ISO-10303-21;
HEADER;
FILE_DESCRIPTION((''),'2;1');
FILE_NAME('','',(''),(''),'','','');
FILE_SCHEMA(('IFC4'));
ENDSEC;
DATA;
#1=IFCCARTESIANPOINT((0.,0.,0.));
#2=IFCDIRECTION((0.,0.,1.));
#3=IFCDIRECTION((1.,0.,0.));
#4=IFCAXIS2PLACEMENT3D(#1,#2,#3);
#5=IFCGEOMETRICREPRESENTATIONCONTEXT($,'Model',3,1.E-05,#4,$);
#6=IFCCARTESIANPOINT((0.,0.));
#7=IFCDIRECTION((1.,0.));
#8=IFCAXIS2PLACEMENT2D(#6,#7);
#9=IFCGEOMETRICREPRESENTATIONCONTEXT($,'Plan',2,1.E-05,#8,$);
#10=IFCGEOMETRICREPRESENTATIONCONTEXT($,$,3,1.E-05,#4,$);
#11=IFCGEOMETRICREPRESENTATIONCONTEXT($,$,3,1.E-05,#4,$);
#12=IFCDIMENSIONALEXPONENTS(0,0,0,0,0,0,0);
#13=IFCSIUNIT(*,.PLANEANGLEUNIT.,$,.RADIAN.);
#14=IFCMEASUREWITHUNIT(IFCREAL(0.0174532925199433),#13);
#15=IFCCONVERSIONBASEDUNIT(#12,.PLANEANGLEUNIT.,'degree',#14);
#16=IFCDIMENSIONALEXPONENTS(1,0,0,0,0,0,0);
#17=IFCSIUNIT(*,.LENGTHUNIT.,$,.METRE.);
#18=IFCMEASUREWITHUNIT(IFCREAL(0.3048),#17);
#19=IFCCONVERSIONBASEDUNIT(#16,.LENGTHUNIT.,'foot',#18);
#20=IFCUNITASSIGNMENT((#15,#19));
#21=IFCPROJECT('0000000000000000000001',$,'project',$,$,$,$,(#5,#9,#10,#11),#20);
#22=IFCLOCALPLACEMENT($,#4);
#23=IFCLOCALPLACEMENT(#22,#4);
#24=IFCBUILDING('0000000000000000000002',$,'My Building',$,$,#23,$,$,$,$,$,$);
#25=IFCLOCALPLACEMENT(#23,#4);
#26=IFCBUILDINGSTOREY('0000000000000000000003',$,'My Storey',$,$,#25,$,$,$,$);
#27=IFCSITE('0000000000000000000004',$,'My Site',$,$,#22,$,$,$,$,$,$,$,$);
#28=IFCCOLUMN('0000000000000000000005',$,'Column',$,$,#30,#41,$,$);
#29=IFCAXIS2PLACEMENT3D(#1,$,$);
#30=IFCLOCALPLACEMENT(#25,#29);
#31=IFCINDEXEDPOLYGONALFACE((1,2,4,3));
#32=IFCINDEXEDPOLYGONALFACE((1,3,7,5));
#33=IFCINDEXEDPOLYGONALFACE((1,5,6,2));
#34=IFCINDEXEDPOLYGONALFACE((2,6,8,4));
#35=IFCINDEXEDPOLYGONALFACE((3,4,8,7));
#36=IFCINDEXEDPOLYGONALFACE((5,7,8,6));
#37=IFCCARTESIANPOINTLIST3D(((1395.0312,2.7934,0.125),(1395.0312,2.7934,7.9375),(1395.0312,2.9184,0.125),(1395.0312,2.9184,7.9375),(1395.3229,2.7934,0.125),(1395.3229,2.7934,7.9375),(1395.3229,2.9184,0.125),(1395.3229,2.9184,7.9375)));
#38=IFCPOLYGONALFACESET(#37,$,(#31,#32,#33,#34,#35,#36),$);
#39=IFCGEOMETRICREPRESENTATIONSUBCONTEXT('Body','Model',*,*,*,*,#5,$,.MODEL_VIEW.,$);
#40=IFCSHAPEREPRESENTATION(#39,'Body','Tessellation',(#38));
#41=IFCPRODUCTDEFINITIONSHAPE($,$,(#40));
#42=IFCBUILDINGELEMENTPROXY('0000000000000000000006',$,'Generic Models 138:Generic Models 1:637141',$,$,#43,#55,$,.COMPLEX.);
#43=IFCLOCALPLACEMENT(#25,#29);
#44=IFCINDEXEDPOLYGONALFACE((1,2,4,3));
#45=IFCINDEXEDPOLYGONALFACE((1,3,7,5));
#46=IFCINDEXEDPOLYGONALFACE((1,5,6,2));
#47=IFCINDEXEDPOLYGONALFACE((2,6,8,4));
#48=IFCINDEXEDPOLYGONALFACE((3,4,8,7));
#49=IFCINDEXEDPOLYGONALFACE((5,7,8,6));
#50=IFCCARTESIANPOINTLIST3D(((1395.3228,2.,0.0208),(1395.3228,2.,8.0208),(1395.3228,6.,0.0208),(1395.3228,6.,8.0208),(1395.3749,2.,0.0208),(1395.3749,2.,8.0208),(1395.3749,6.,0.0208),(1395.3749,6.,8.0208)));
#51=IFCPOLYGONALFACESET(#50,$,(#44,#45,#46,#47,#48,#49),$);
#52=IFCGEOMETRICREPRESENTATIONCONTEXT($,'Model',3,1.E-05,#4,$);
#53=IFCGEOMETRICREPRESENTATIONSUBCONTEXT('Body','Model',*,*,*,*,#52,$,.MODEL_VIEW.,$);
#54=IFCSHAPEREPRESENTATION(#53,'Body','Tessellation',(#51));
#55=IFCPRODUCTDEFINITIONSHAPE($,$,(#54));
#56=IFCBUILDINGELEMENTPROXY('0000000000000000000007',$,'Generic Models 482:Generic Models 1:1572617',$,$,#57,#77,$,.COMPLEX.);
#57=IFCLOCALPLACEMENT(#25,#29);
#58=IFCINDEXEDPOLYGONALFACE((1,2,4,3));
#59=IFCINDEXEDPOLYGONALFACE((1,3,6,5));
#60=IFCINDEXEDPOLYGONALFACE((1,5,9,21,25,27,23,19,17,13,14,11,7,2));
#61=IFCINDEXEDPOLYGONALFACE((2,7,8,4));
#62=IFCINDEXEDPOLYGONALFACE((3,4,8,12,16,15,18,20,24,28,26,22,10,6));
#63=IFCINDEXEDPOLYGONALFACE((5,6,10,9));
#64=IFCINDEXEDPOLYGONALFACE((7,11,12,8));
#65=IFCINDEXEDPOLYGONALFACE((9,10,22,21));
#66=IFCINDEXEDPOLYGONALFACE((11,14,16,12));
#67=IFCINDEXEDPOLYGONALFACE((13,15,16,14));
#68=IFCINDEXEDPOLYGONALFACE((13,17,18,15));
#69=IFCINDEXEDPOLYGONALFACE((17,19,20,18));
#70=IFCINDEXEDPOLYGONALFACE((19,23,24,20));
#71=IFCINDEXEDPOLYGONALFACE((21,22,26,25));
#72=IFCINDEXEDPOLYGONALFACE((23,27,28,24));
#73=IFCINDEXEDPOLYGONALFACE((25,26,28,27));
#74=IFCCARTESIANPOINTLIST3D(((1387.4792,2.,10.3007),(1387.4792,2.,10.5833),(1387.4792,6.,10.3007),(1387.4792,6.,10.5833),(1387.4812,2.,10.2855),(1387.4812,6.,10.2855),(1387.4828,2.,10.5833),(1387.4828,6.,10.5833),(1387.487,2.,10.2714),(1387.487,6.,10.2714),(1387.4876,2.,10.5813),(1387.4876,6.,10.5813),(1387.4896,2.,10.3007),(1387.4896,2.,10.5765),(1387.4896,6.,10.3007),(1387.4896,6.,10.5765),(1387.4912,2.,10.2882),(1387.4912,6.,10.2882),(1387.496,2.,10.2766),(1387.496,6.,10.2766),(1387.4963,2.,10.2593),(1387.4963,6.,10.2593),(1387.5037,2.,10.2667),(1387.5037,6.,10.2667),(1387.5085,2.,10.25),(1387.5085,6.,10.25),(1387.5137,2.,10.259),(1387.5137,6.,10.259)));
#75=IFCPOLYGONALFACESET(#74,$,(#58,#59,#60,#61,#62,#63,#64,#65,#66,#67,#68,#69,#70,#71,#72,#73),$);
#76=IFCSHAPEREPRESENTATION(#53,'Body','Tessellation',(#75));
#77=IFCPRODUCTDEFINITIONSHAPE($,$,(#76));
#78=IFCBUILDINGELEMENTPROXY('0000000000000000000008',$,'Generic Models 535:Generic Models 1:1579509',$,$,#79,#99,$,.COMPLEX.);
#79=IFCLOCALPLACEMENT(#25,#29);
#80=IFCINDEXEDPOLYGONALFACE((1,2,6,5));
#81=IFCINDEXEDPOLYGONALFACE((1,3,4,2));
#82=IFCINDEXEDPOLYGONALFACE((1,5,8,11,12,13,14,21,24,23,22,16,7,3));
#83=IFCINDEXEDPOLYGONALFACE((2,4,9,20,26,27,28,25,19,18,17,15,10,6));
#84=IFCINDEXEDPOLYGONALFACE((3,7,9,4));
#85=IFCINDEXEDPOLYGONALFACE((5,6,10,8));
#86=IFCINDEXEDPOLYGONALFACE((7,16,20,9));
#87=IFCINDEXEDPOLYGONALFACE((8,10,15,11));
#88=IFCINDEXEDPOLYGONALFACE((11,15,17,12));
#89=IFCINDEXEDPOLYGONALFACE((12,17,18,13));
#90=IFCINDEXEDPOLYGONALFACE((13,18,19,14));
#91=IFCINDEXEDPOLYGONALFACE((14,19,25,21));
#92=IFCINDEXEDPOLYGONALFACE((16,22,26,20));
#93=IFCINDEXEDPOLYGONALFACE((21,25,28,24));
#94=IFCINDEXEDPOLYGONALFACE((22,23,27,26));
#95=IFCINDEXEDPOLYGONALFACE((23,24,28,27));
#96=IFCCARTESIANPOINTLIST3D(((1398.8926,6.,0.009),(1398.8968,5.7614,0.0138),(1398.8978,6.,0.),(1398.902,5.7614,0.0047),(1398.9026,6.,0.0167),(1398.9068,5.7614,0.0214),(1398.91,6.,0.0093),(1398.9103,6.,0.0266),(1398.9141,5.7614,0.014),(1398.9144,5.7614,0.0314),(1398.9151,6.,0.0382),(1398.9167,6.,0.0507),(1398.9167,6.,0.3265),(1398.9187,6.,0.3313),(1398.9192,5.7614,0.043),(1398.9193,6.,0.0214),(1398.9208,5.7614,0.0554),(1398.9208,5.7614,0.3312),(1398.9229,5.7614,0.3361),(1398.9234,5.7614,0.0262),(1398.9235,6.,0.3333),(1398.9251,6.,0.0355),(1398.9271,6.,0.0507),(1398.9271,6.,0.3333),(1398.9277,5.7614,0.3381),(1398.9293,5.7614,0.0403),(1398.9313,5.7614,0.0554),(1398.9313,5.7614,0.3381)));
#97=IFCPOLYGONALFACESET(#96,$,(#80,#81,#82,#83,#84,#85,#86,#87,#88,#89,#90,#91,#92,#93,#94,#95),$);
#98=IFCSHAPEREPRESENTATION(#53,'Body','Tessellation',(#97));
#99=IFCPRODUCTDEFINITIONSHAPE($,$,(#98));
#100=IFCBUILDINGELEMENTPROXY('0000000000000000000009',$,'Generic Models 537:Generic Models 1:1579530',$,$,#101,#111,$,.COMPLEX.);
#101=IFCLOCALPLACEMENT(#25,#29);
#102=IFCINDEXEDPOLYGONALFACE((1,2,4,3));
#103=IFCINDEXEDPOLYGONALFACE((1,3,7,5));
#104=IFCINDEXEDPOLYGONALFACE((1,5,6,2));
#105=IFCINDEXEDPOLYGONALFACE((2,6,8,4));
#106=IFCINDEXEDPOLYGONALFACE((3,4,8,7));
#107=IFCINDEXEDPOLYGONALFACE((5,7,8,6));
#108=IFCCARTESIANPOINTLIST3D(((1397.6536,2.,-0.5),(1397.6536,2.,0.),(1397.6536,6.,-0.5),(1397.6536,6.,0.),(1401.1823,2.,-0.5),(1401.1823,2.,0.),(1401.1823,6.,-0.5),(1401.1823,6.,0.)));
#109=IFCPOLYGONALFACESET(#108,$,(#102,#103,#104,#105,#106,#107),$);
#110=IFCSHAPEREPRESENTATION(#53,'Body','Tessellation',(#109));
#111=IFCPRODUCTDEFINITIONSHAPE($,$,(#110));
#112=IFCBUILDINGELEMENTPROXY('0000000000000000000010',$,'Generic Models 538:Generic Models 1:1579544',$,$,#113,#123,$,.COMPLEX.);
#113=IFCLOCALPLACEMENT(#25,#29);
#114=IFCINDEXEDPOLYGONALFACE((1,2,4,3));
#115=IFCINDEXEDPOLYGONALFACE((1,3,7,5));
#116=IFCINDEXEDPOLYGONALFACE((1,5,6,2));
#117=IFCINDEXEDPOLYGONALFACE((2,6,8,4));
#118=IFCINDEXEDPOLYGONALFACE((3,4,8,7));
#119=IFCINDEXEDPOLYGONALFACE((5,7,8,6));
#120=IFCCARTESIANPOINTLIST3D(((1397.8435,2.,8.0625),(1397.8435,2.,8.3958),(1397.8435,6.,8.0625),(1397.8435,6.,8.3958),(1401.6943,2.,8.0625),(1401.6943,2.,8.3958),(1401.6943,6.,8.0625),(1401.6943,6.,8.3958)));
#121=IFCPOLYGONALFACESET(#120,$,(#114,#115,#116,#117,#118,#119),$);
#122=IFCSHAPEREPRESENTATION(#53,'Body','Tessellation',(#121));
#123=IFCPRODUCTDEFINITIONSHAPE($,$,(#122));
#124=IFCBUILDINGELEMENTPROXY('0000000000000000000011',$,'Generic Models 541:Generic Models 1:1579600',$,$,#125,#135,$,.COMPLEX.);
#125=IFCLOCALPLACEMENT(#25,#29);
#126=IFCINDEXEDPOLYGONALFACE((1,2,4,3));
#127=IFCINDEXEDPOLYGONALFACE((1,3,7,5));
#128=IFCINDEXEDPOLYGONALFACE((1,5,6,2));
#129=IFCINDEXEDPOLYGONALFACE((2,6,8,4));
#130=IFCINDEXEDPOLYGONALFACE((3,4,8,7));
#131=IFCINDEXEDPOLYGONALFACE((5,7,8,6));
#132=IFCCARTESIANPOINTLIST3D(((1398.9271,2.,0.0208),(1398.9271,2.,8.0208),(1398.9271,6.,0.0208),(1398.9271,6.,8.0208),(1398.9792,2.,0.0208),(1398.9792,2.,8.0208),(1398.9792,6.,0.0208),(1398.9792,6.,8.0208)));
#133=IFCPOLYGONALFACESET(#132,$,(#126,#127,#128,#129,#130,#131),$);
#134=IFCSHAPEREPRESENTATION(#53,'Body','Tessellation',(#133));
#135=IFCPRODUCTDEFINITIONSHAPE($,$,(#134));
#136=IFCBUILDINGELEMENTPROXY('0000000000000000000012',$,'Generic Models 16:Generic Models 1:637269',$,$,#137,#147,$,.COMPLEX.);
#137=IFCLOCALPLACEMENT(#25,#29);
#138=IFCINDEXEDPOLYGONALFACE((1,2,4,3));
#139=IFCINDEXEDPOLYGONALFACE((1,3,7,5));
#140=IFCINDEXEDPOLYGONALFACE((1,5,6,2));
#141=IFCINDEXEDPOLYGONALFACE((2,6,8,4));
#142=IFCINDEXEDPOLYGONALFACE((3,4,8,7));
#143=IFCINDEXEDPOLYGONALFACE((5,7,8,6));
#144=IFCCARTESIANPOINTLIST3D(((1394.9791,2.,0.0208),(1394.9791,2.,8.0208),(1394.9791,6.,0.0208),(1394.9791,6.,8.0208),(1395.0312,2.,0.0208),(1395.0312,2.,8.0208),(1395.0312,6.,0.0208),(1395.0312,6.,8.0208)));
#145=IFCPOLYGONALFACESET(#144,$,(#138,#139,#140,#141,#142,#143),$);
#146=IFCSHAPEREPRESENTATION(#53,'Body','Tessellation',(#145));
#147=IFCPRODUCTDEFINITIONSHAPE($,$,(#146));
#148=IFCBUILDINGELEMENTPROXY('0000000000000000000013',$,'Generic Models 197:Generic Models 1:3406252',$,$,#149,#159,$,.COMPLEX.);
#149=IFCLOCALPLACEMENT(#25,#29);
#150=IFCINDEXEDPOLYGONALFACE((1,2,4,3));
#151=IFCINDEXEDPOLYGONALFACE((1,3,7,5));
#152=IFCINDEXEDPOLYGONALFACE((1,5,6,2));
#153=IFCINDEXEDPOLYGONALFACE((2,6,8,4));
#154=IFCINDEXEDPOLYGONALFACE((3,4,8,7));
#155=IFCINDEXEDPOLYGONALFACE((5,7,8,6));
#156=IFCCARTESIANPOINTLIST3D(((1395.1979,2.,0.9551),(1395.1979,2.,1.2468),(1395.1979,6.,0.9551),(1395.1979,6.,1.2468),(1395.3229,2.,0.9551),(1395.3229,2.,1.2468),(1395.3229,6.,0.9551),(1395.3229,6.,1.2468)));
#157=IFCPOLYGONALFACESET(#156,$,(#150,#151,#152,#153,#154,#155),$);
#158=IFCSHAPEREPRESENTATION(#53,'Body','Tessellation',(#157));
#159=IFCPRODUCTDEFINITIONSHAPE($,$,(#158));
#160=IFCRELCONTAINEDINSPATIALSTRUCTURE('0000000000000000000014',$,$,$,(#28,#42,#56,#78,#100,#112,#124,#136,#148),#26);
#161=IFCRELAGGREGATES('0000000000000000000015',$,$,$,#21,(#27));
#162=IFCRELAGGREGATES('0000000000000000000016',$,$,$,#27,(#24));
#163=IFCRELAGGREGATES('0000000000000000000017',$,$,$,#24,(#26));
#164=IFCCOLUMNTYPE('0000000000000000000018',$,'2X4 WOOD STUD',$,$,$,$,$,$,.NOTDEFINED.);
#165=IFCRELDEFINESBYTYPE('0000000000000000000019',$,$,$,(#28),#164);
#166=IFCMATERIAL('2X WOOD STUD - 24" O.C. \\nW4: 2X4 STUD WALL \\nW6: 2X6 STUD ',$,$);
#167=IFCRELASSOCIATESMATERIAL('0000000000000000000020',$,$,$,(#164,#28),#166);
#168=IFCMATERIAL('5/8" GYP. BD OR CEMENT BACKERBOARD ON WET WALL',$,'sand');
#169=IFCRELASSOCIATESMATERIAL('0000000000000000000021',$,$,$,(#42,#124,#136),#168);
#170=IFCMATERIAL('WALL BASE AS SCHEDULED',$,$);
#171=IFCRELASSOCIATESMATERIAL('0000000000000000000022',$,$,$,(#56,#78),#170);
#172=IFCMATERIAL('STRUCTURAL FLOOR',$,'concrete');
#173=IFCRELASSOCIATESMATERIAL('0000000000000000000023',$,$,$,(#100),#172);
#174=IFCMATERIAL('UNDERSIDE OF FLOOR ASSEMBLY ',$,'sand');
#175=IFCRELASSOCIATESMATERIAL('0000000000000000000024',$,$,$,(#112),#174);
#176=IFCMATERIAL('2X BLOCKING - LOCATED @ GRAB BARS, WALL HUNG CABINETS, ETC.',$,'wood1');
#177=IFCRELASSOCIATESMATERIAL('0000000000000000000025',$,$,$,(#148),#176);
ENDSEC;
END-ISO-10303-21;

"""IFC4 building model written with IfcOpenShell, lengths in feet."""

from ifc_helpers import new_model, entity, si_unit, converted_unit, frame, origin_with_axes, origin_2d_with_axis, place, context, subcontext, project, spatial, polyline, line, indexed_curve, outline, extrude, material, material_profile, profile_set, profile_usage, type_object, element, save


model = new_model("IFC4")

# Units and contexts
model_context_1 = context("Model", 3, precision=1e-05, world=origin_with_axes())
plan_context = context("Plan", 2, precision=1e-05, world=origin_2d_with_axis())
model_context_2 = context("Model", 3, precision=1e-05, world=origin_with_axes())
context_of_model_1 = context(None, 3, precision=1e-05, world=origin_with_axes())
context_of_model_2 = context(None, 3, precision=1e-05, world=origin_with_axes())
body_context_1 = subcontext(model_context_1, "Body", "Model", "MODEL_VIEW")
body_context_2 = subcontext(model_context_2, "Body", "Model", "MODEL_VIEW")
ifc_project = project(units=[converted_unit("PLANEANGLEUNIT", "degree", entity("IfcReal", 0.0174532925199433), si_unit("PLANEANGLEUNIT", "RADIAN"), dimensions=[0, 0, 0, 0, 0, 0, 0]), converted_unit("LENGTHUNIT", "foot", entity("IfcReal", 0.3048), si_unit("LENGTHUNIT", "METRE"), dimensions=[1, 0, 0, 0, 0, 0, 0])], contexts=[model_context_1, plan_context, context_of_model_1, context_of_model_2])

# Site, building, storey
site_placement = place(None, origin_with_axes())
site = spatial("IfcSite", under=ifc_project, at=site_placement, Name="My Site")
building_placement = place(site_placement, origin_with_axes())
building = spatial("IfcBuilding", under=site, at=building_placement, Name="My Building")
storey_placement = place(building_placement, origin_with_axes())
storey = spatial("IfcBuildingStorey", under=building, at=storey_placement, Name="My Storey")

# Column
ifc_material_1 = material(Name="2X WOOD STUD - 24\" O.C. \\nW4: 2X4 STUD WALL \\nW6: 2X6 STUD ")
ifc_material_profile = material_profile(ifc_material_1, outline(indexed_curve([(0.2917, 0.125), (0.0, 0.125), (0.0, 0.0), (0.2917, 0.0)], segments=[line(3, 2), line(2, 1), line(1, 4), line(4, 3)], self_intersect=False)))
ifc_profile_set = profile_set([ifc_material_profile])
ifc_profile_usage = profile_usage(ifc_profile_set, cardinal=5)
column_type = type_object("IfcColumnType", Name="2X4 WOOD STUD", PredefinedType="NOTDEFINED", material=ifc_profile_set)
column_placement = place(storey_placement, frame((1395.0312, 2.7934, 0.125), z_axis=(0.0, 0.0, 1.0), x_axis=(1.0, 0.0, 0.0)))
element("IfcColumn", 1, at=column_placement, inside=storey, type_object=column_type, material=ifc_profile_usage, Name="Column", context=body_context_1, shape_type="SweptSolid", body=[
    extrude(outline(indexed_curve([(0.2917, 0.125), (0.0, 0.125), (0.0, 0.0), (0.2917, 0.0)], segments=[line(3, 2), line(2, 1), line(1, 4), line(4, 3)], self_intersect=False)), origin_with_axes(), (0.0, 0.0, 1.0), 7.8125),
])

# Building element proxies
ifc_material_2 = material(Name="5/8\" GYP. BD OR CEMENT BACKERBOARD ON WET WALL", Category="sand")
proxy_1_placement = place(storey_placement, frame((1395.3228, 6.0, 0.0208), z_axis=(0.0, -1.0, 0.0), x_axis=(0.0, 0.0, 1.0)))
element("IfcBuildingElementProxy", 2, at=proxy_1_placement, inside=storey, material=ifc_material_2, Name="Generic Models 138:Generic Models 1:637141", PredefinedType="COMPLEX", context=body_context_2, shape_type="SweptSolid", body=[
    extrude(outline(polyline([(-0.026, -4.0), (0.026, -4.0), (0.026, 4.0), (-0.026, 4.0), (-0.026, -4.0)])), frame((4.0, -0.026, 0.0), z_axis=(0.0, 0.0, -1.0), x_axis=(0.0, 1.0, 0.0)), (0.0, 0.0, -1.0), 4.0),
])
ifc_material_3 = material(Name="WALL BASE AS SCHEDULED")
proxy_2_placement = place(storey_placement, frame((1387.4792, 6.0, 10.25), z_axis=(0.0, -1.0, 0.0), x_axis=(0.0, 0.0, 1.0)))
element("IfcBuildingElementProxy", 3, at=proxy_2_placement, inside=storey, material=ifc_material_3, Name="Generic Models 482:Generic Models 1:1572617", PredefinedType="COMPLEX", context=body_context_2, shape_type="SweptSolid", body=[
    extrude(outline(polyline([(0.2206, 0.0), (0.2204, 0.0036), (0.2182, 0.0083), (0.2132, 0.01), (-0.0621, -0.0058), (-0.0747, -0.0049), (-0.0865, -0.0007), (-0.0969, 0.0063), (-0.1051, 0.0158), (-0.1138, 0.0101), (-0.1038, -0.0014), (-0.0912, -0.01), (-0.0768, -0.0151), (-0.0615, -0.0162), (0.2206, 0.0)])), frame((0.113, -0.0126, 0.0), z_axis=(0.0, 0.0, -1.0), x_axis=(0.998358, 0.057286, 0.0)), (0.0, 0.0, -1.0), 4.0),
])
proxy_3_placement = place(storey_placement, frame((1398.8926, 6.0, 0.0), z_axis=(0.0, -1.0, 0.0), x_axis=(0.0, 0.0, 1.0)))
element("IfcBuildingElementProxy", 4, at=proxy_3_placement, inside=storey, material=ifc_material_3, Name="Generic Models 535:Generic Models 1:1579509", PredefinedType="COMPLEX", context=body_context_2, shape_type="SweptSolid", body=[
    extrude(outline(polyline([(-0.2203, -0.0126), (0.0624, -0.0126), (0.0775, -0.0106), (0.0916, -0.0048), (0.1037, 0.0045), (0.113, 0.0166), (0.104, 0.0218), (0.0964, 0.0119), (0.0864, 0.0042), (0.0748, -0.0006), (0.0624, -0.0022), (-0.2134, -0.0022), (-0.2183, -0.0042), (-0.2203, -0.0091), (-0.2203, -0.0126)])), frame((0.113, -0.0218, 0.0), z_axis=(0.0, 0.0, -1.0), x_axis=(-1.0, 0.0, 0.0)), (-0.01982, -0.017382, -0.999652), 0.2387),
])
ifc_material_4 = material(Name="STRUCTURAL FLOOR", Category="concrete")
proxy_4_placement = place(storey_placement, frame((1397.1823, 6.0, -0.5), z_axis=(0.0, -1.0, 0.0), x_axis=(0.0, 0.0, 1.0)))
element("IfcBuildingElementProxy", 5, at=proxy_4_placement, inside=storey, material=ifc_material_4, Name="Generic Models 537:Generic Models 1:1579530", PredefinedType="COMPLEX", context=body_context_2, shape_type="SweptSolid", body=[
    extrude(outline(indexed_curve([(-0.25, -1.5287), (0.25, -1.5287), (0.25, 2.0), (-0.25, 2.0)], segments=[line(4, 1), line(1, 2), line(2, 3), line(3, 4)], self_intersect=False)), frame((0.25, -2.0, 0.0), z_axis=(0.0, 0.0, -1.0), x_axis=(1.0, 0.0, 0.0)), (0.0, 0.0, -1.0), 4.0),
])
ifc_material_5 = material(Name="UNDERSIDE OF FLOOR ASSEMBLY ", Category="sand")
proxy_5_placement = place(storey_placement, frame((1397.6943, 6.0, 8.0625), z_axis=(0.0, -1.0, 0.0), x_axis=(0.0, 0.0, 1.0)))
element("IfcBuildingElementProxy", 6, at=proxy_5_placement, inside=storey, material=ifc_material_5, Name="Generic Models 538:Generic Models 1:1579544", PredefinedType="COMPLEX", context=body_context_2, shape_type="SweptSolid", body=[
    extrude(outline(indexed_curve([(-0.1667, -1.8508), (0.1667, -1.8508), (0.1667, 2.0), (-0.1667, 2.0)], segments=[line(4, 1), line(1, 2), line(2, 3), line(3, 4)], self_intersect=False)), frame((0.1667, -2.0, 0.0), z_axis=(0.0, 0.0, -1.0), x_axis=(1.0, 0.0, 0.0)), (0.0, 0.0, -1.0), 4.0),
])
proxy_6_placement = place(storey_placement, frame((1398.9271, 6.0, 0.0208), z_axis=(0.0, -1.0, 0.0), x_axis=(0.0, 0.0, 1.0)))
element("IfcBuildingElementProxy", 7, at=proxy_6_placement, inside=storey, material=ifc_material_2, Name="Generic Models 541:Generic Models 1:1579600", PredefinedType="COMPLEX", context=body_context_2, shape_type="SweptSolid", body=[
    extrude(outline(polyline([(-4.0, -0.026), (4.0, -0.026), (4.0, 0.026), (-4.0, 0.026), (-4.0, -0.026)])), frame((4.0, -0.026, 0.0), z_axis=(0.0, 0.0, -1.0), x_axis=(1.0, 0.0, 0.0)), (0.0, 0.0, -1.0), 4.0),
])
proxy_7_placement = place(storey_placement, frame((1394.9791, 6.0, 0.0208), z_axis=(0.0, -1.0, 0.0), x_axis=(0.0, 0.0, 1.0)))
element("IfcBuildingElementProxy", 8, at=proxy_7_placement, inside=storey, material=ifc_material_2, Name="Generic Models 16:Generic Models 1:637269", PredefinedType="COMPLEX", context=body_context_2, shape_type="SweptSolid", body=[
    extrude(outline(polyline([(-0.026, -4.0), (0.026, -4.0), (0.026, 4.0), (-0.026, 4.0), (-0.026, -4.0)])), frame((4.0, -0.026, 0.0), z_axis=(0.0, 0.0, -1.0), x_axis=(0.0, 1.0, 0.0)), (0.0, 0.0, -1.0), 4.0),
])
ifc_material_6 = material(Name="2X BLOCKING - LOCATED @ GRAB BARS, WALL HUNG CABINETS, ETC.", Category="wood1")
proxy_8_placement = place(storey_placement, frame((1395.1979, 6.0, 0.9551), z_axis=(0.0, -1.0, 0.0), x_axis=(0.0, 0.0, 1.0)))
element("IfcBuildingElementProxy", 9, at=proxy_8_placement, inside=storey, material=ifc_material_6, Name="Generic Models 197:Generic Models 1:3406252", PredefinedType="COMPLEX", context=body_context_2, shape_type="SweptSolid", body=[
    extrude(outline(polyline([(-0.0625, -0.1458), (0.0625, -0.1458), (0.0625, 0.1458), (-0.0625, 0.1458), (-0.0625, -0.1458)])), frame((0.1458, -0.0625, 0.0), z_axis=(0.0, 0.0, -1.0), x_axis=(0.0, -1.0, 0.0)), (0.0, 0.0, -1.0), 4.0),
])

save(model, "model.ifc")
